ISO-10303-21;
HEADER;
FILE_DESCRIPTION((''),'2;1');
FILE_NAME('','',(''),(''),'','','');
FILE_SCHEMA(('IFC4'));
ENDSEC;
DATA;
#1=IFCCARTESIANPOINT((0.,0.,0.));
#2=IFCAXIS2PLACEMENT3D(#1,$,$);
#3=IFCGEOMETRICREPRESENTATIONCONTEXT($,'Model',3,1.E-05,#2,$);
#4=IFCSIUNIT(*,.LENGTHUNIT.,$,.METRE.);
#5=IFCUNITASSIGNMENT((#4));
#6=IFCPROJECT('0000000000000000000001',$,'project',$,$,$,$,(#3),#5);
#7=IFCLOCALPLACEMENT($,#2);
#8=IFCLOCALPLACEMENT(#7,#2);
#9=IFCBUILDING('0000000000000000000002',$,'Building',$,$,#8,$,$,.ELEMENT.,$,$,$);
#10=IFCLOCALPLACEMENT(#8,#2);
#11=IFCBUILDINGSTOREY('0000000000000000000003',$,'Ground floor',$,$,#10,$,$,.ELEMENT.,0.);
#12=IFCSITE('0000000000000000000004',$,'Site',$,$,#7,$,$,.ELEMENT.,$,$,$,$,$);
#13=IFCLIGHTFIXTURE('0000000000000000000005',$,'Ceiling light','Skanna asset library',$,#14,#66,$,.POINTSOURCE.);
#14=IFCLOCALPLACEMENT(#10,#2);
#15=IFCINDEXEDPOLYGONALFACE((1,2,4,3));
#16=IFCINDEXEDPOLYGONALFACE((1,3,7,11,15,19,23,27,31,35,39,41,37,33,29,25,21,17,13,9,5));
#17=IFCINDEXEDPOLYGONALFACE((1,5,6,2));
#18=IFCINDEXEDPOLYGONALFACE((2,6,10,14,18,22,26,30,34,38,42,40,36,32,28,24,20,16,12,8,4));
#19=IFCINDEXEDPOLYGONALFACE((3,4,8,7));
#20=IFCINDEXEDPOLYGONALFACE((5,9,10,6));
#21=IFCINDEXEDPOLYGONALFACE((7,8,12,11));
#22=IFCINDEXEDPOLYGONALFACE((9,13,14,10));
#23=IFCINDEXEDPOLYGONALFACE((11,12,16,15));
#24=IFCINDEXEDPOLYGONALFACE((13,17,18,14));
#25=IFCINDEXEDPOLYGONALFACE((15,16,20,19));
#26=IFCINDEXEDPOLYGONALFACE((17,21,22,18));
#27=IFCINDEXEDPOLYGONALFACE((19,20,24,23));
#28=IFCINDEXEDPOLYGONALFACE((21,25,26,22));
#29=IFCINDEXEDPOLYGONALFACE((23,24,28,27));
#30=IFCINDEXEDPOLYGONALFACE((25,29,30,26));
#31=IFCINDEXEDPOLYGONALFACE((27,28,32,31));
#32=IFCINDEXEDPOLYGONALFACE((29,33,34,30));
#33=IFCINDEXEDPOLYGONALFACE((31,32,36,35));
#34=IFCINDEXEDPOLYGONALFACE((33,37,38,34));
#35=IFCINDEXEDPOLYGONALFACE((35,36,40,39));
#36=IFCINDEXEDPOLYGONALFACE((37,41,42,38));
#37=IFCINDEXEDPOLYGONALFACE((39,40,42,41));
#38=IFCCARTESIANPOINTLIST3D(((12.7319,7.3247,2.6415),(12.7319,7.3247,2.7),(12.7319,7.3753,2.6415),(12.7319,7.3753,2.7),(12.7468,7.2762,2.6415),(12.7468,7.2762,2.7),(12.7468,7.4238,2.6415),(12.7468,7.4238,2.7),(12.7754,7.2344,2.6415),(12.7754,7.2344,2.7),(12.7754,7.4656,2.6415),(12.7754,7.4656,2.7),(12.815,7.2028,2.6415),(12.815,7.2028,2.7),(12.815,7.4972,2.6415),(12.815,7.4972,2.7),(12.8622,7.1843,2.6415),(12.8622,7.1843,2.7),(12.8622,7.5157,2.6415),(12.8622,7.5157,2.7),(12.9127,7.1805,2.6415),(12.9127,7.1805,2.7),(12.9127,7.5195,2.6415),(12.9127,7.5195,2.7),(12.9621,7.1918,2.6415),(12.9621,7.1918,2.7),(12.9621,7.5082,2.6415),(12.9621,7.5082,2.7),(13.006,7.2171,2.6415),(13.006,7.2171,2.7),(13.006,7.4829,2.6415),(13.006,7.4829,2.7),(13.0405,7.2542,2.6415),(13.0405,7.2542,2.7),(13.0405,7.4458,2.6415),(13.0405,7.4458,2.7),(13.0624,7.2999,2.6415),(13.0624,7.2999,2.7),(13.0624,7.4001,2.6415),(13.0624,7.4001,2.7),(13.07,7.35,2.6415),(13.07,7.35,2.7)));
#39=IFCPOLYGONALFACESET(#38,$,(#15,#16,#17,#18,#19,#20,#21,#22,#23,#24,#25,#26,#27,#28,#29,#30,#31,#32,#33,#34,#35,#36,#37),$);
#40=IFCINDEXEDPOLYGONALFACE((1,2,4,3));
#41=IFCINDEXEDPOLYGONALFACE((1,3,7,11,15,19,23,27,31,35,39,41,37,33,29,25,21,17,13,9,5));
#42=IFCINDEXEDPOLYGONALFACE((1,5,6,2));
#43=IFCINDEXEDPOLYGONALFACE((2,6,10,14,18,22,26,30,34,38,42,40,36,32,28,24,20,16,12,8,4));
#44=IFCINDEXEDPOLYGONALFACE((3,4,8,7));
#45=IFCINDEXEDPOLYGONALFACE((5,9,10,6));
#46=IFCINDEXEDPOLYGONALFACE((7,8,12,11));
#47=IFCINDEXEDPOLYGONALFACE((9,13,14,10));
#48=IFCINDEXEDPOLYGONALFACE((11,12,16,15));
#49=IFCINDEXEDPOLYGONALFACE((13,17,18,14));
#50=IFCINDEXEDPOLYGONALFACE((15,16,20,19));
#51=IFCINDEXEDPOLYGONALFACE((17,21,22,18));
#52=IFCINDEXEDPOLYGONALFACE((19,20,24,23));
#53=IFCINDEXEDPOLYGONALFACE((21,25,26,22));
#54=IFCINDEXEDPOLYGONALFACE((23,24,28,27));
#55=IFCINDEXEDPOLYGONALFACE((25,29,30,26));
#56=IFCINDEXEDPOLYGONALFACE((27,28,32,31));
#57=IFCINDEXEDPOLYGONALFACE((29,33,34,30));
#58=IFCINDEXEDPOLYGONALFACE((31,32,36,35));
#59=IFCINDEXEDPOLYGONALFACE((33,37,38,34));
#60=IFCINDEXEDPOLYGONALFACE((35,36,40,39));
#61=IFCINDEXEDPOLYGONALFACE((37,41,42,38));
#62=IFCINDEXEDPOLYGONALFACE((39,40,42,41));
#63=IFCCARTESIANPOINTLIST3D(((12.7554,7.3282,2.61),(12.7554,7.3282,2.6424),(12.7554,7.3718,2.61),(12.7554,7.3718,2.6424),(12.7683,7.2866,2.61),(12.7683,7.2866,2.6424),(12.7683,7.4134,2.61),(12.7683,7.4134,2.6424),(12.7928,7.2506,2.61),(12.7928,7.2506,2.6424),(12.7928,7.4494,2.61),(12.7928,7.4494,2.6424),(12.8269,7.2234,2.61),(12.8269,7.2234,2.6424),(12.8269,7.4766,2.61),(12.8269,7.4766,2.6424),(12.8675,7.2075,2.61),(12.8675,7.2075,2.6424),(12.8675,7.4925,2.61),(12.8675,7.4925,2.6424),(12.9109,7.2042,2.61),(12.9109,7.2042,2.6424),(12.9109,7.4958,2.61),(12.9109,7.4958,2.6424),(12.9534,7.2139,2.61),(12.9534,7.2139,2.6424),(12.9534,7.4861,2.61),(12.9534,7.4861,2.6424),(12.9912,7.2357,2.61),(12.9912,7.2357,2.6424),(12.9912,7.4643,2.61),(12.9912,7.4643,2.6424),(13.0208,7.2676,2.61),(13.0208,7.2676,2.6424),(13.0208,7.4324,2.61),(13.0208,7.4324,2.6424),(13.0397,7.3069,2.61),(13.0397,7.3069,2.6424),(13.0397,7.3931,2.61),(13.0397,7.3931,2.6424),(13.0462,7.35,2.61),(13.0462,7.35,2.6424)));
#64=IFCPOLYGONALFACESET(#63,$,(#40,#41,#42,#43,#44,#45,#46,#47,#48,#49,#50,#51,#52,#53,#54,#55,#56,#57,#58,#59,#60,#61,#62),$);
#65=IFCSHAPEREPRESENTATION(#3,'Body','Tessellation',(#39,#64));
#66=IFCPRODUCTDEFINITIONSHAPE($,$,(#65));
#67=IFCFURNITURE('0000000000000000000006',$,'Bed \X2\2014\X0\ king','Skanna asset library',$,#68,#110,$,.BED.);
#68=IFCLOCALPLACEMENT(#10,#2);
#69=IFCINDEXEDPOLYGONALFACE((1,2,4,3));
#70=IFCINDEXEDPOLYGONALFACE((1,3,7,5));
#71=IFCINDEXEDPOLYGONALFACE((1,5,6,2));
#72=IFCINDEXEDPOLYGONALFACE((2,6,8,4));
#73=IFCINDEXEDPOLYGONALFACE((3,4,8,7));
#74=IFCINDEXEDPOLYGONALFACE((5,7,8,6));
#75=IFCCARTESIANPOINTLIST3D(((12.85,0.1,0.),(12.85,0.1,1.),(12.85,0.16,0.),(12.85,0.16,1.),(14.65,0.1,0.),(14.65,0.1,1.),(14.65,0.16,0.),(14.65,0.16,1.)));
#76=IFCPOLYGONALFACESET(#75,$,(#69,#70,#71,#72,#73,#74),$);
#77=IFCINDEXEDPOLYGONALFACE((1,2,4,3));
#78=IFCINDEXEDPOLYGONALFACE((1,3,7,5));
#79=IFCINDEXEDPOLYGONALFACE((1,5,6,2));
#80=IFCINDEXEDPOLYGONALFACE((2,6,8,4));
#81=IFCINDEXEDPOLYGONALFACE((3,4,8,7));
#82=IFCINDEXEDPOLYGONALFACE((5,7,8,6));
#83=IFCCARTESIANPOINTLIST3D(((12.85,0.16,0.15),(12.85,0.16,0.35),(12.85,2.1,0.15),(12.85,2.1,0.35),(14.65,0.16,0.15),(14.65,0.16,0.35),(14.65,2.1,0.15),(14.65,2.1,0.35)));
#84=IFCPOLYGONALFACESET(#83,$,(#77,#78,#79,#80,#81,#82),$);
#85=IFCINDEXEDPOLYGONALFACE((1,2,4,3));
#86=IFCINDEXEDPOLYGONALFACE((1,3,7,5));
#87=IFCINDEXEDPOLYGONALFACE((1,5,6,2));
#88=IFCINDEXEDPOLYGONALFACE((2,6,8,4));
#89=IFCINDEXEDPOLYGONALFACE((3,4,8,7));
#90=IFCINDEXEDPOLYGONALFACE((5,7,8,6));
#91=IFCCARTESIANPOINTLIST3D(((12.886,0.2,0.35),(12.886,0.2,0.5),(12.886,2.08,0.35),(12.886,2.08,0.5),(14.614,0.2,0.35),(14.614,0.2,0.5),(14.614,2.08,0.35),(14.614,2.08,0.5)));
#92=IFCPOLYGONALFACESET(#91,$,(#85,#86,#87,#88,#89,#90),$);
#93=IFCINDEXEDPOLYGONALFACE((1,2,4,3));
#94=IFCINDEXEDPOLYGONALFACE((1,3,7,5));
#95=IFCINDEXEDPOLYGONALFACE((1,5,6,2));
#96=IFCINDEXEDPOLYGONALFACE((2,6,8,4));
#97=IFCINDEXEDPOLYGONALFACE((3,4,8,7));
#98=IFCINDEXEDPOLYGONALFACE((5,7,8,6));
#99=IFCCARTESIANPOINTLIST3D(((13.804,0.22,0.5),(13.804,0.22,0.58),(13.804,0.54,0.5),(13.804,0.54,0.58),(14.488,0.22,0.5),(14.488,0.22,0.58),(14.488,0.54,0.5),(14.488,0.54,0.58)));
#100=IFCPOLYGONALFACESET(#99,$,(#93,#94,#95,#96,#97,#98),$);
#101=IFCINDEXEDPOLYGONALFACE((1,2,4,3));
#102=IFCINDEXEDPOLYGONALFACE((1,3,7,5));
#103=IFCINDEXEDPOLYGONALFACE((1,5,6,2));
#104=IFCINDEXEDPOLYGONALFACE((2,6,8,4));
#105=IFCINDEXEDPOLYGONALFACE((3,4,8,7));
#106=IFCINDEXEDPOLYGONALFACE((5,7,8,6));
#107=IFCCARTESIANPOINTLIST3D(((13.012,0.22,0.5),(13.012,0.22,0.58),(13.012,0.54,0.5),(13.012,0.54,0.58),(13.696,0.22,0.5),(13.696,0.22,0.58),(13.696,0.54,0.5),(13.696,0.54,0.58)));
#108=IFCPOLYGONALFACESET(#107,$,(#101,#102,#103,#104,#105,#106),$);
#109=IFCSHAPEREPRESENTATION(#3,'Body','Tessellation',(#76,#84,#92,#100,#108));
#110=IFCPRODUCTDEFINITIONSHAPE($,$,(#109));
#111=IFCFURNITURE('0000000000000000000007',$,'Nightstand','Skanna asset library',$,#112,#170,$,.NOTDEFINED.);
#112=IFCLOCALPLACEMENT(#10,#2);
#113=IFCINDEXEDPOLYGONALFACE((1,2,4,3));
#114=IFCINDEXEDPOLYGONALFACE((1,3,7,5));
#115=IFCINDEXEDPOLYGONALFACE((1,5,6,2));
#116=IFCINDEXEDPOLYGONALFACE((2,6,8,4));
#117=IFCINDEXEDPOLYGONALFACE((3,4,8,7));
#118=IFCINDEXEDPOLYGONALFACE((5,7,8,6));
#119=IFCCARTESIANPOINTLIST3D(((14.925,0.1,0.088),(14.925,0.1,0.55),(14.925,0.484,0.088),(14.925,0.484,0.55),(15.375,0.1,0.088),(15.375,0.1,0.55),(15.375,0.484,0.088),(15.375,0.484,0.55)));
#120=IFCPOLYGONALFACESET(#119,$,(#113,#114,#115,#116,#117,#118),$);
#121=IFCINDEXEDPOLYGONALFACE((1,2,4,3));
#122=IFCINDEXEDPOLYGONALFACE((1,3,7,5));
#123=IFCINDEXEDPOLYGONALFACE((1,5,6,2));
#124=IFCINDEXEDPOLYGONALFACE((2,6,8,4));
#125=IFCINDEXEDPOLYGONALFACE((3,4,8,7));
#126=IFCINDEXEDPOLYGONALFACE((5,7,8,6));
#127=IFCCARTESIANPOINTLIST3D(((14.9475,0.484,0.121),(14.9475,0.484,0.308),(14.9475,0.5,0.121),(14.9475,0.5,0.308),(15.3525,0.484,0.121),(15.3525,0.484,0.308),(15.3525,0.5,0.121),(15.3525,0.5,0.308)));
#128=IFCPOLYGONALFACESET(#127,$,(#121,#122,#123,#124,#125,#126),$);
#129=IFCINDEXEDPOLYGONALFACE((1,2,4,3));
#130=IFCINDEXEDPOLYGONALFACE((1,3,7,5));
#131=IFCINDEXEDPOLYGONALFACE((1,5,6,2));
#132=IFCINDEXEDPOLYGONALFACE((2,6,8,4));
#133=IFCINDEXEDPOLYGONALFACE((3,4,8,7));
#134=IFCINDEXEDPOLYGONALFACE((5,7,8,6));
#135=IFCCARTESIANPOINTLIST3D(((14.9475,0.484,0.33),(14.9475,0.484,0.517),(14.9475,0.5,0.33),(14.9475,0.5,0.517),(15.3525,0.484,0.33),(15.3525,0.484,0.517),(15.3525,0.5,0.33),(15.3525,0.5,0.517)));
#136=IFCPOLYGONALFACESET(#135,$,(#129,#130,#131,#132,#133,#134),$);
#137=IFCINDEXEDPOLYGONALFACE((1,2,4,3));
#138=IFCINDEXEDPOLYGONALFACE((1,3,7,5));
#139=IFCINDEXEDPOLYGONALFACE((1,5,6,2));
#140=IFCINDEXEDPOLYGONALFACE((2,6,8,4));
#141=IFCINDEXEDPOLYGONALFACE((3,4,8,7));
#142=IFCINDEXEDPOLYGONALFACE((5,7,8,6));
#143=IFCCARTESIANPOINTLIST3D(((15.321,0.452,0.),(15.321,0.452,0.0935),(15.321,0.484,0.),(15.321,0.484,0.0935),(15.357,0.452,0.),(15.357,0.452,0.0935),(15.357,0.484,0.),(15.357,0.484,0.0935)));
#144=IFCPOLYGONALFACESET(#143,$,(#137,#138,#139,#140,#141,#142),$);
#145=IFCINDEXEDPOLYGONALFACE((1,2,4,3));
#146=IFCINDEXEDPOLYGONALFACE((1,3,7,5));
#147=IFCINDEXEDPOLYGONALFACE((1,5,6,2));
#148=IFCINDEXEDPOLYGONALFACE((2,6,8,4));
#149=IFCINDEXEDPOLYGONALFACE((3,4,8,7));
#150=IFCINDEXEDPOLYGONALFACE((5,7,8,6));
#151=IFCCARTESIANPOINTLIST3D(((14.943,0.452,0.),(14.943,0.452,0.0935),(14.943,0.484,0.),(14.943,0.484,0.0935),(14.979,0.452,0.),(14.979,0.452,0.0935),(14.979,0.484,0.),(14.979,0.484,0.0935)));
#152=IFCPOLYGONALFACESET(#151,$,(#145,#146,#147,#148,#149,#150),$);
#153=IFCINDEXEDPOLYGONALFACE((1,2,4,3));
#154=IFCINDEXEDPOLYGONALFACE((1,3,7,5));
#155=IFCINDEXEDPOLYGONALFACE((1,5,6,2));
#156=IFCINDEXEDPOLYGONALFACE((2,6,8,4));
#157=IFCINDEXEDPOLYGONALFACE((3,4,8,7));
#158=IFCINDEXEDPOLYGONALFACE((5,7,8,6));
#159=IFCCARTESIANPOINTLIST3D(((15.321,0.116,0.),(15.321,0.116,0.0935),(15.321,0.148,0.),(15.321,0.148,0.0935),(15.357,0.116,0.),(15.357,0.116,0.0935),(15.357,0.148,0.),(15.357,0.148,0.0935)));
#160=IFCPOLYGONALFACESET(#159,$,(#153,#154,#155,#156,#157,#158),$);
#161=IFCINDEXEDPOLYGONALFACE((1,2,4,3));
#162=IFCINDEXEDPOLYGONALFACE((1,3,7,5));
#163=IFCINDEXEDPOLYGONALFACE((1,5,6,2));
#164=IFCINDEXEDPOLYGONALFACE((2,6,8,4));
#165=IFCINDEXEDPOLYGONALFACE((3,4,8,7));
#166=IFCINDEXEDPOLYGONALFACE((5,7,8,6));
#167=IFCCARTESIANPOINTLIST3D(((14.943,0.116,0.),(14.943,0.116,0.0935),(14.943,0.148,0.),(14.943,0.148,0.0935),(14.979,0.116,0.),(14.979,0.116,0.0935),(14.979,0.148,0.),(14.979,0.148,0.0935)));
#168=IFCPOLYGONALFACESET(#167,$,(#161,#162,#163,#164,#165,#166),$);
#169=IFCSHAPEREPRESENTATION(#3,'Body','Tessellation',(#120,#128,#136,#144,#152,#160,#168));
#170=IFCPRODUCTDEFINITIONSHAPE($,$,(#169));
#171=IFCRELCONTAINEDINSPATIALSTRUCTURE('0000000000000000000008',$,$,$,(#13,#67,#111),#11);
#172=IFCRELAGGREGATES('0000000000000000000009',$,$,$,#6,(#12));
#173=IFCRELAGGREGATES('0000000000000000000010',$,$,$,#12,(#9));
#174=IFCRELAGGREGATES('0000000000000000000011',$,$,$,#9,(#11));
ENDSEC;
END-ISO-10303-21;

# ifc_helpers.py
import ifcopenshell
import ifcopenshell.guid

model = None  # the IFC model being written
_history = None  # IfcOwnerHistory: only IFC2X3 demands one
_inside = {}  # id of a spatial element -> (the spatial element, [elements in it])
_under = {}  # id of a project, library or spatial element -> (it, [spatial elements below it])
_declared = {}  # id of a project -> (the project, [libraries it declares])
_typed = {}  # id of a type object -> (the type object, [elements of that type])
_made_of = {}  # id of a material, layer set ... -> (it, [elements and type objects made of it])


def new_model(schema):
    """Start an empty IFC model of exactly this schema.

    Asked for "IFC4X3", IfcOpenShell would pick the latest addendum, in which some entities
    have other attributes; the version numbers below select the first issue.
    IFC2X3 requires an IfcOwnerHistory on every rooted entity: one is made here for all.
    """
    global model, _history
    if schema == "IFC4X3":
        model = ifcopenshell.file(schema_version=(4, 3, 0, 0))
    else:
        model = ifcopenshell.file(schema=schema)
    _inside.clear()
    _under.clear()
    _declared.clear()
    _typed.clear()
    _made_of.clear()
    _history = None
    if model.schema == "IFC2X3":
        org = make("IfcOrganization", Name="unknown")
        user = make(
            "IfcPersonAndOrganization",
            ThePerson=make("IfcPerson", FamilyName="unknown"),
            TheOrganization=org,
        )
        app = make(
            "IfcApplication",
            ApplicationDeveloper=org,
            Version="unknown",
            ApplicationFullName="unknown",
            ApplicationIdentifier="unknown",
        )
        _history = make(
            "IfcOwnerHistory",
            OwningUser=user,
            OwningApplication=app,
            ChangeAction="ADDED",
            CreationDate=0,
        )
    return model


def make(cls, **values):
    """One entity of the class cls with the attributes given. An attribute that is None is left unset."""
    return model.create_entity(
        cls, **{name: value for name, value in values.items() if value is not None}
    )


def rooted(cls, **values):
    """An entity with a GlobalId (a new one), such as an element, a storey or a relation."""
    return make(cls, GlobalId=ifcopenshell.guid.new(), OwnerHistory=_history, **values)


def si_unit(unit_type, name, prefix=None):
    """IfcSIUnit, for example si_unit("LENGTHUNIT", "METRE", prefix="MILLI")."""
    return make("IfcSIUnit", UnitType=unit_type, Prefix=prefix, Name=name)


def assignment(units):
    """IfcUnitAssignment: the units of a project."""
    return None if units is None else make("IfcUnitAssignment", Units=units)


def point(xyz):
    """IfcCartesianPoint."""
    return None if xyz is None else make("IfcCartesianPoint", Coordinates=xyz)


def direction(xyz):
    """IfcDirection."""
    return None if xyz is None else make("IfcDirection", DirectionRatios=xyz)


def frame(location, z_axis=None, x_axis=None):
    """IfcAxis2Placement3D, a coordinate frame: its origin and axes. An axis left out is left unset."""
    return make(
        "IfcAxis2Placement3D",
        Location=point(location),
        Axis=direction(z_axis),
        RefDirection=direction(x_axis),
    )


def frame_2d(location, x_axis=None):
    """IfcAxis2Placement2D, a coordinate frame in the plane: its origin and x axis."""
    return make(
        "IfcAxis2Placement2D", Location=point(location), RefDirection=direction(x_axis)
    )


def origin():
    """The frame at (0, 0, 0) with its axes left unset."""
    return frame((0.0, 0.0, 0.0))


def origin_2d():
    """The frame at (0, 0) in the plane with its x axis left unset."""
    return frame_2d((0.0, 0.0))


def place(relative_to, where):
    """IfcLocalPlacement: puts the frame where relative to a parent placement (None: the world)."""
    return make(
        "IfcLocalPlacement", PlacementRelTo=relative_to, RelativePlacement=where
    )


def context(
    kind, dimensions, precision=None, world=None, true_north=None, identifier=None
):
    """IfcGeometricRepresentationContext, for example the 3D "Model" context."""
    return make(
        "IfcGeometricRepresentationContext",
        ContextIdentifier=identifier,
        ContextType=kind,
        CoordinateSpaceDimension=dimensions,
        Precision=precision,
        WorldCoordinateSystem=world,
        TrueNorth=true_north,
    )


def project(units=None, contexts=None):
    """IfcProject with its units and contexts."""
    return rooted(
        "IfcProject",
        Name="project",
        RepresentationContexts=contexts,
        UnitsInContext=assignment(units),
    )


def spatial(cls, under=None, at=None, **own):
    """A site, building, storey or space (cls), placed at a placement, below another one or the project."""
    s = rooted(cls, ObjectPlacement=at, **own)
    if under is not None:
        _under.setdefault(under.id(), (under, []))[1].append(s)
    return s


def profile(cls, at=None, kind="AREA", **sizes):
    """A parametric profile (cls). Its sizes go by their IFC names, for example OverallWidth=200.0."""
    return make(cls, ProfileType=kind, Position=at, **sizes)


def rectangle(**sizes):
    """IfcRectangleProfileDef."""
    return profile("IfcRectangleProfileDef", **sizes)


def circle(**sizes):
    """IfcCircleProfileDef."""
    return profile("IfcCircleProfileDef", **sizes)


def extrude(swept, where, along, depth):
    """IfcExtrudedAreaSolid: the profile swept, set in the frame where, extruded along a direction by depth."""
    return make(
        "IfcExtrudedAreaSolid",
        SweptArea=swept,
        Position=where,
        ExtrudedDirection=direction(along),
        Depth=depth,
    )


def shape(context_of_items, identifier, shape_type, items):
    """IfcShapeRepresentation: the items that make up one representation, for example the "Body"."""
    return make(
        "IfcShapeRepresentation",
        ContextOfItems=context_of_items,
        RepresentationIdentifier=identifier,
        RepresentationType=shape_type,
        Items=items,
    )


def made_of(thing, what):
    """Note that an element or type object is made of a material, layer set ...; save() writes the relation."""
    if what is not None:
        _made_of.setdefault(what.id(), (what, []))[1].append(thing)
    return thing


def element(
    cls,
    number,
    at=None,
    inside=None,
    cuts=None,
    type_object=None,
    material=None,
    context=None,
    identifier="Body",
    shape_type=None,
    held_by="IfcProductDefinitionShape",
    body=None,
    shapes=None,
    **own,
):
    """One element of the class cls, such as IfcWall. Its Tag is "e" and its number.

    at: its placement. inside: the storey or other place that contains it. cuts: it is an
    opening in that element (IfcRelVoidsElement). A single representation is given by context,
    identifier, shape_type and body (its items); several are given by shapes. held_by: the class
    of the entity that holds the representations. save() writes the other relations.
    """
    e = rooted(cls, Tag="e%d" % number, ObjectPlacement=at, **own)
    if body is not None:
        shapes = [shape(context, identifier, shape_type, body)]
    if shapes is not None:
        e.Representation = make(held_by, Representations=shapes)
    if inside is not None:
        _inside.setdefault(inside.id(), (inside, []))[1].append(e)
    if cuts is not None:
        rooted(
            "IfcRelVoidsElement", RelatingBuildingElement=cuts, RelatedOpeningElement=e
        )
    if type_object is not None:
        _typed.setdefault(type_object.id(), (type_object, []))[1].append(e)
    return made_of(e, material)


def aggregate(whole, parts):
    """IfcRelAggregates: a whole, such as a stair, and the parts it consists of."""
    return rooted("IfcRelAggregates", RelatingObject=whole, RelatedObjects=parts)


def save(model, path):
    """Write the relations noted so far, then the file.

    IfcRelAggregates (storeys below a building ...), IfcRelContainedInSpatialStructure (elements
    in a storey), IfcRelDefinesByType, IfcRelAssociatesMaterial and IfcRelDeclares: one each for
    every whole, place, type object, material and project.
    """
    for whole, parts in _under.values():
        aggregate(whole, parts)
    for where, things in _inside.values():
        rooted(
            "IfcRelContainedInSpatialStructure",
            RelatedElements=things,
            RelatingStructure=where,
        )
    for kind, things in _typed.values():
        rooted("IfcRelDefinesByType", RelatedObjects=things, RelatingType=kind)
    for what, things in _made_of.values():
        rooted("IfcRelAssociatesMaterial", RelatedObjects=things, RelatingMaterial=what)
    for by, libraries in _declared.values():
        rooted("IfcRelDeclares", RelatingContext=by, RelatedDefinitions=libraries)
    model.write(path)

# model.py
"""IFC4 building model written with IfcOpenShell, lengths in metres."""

from ifc_helpers import new_model, si_unit, frame, frame_2d, origin, origin_2d, place, context, project, spatial, rectangle, circle, extrude, element, save


model = new_model("IFC4")

# Units and contexts
model_context = context("Model", 3, precision=1e-05, world=origin())
ifc_project = project(units=[si_unit("LENGTHUNIT", "METRE")], contexts=[model_context])

# Site, building, storey
site_placement = place(None, origin())
site = spatial("IfcSite", under=ifc_project, at=site_placement, Name="Site", CompositionType="ELEMENT")
building_placement = place(site_placement, origin())
building = spatial("IfcBuilding", under=site, at=building_placement, Name="Building", CompositionType="ELEMENT")
storey_placement = place(building_placement, origin())
storey = spatial("IfcBuildingStorey", under=building, at=storey_placement, Name="Ground floor", CompositionType="ELEMENT", Elevation=0.0)

# Light fixture
light_fixture_1_placement = place(storey_placement, frame((12.9, 7.35, 2.61), z_axis=(0.0, 0.0, 1.0), x_axis=(1.0, 0.0, 0.0)))
element("IfcLightFixture", 1, at=light_fixture_1_placement, inside=storey, Name="Ceiling light", Description="Skanna asset library", PredefinedType="POINTSOURCE", context=model_context, shape_type="SweptSolid", body=[
    extrude(circle(Radius=0.17, at=origin_2d()), frame((0.0, 0.0, 0.0315)), (0.0, 0.0, 1.0), 0.0585),
    extrude(circle(Radius=0.1462, at=origin_2d()), origin(), (0.0, 0.0, 1.0), 0.0324),
])

# Furniture
furniture_1_placement = place(storey_placement, frame((13.75, 1.1, 0.0), z_axis=(0.0, 0.0, 1.0), x_axis=(-1.0, 0.0, 0.0)))
element("IfcFurniture", 2, at=furniture_1_placement, inside=storey, Name="Bed — king", Description="Skanna asset library", PredefinedType="BED", context=model_context, shape_type="SweptSolid", body=[
    extrude(rectangle(XDim=1.8, YDim=0.06, at=frame_2d((0.0, 0.97))), origin(), (0.0, 0.0, 1.0), 1.0),
    extrude(rectangle(XDim=1.8, YDim=1.94, at=frame_2d((0.0, -0.03))), frame((0.0, 0.0, 0.15)), (0.0, 0.0, 1.0), 0.2),
    extrude(rectangle(XDim=1.728, YDim=1.88, at=frame_2d((0.0, -0.04))), frame((0.0, 0.0, 0.35)), (0.0, 0.0, 1.0), 0.15),
    extrude(rectangle(XDim=0.684, YDim=0.32, at=frame_2d((-0.396, 0.72))), frame((0.0, 0.0, 0.5)), (0.0, 0.0, 1.0), 0.08),
    extrude(rectangle(XDim=0.684, YDim=0.32, at=frame_2d((0.396, 0.72))), frame((0.0, 0.0, 0.5)), (0.0, 0.0, 1.0), 0.08),
])
furniture_2_placement = place(storey_placement, frame((15.15, 0.3, 0.0), z_axis=(0.0, 0.0, 1.0), x_axis=(-1.0, 0.0, 0.0)))
element("IfcFurniture", 3, at=furniture_2_placement, inside=storey, Name="Nightstand", Description="Skanna asset library", PredefinedType="NOTDEFINED", context=model_context, shape_type="SweptSolid", body=[
    extrude(rectangle(XDim=0.45, YDim=0.384, at=frame_2d((0.0, 0.008))), frame((0.0, 0.0, 0.088)), (0.0, 0.0, 1.0), 0.462),
    extrude(rectangle(XDim=0.405, YDim=0.016, at=frame_2d((0.0, -0.192))), frame((0.0, 0.0, 0.121)), (0.0, 0.0, 1.0), 0.187),
    extrude(rectangle(XDim=0.405, YDim=0.016, at=frame_2d((0.0, -0.192))), frame((0.0, 0.0, 0.33)), (0.0, 0.0, 1.0), 0.187),
    extrude(rectangle(XDim=0.036, YDim=0.032, at=frame_2d((-0.189, -0.168))), origin(), (0.0, 0.0, 1.0), 0.0935),
    extrude(rectangle(XDim=0.036, YDim=0.032, at=frame_2d((0.189, -0.168))), origin(), (0.0, 0.0, 1.0), 0.0935),
    extrude(rectangle(XDim=0.036, YDim=0.032, at=frame_2d((-0.189, 0.168))), origin(), (0.0, 0.0, 1.0), 0.0935),
    extrude(rectangle(XDim=0.036, YDim=0.032, at=frame_2d((0.189, 0.168))), origin(), (0.0, 0.0, 1.0), 0.0935),
])

save(model, "model.ifc")
